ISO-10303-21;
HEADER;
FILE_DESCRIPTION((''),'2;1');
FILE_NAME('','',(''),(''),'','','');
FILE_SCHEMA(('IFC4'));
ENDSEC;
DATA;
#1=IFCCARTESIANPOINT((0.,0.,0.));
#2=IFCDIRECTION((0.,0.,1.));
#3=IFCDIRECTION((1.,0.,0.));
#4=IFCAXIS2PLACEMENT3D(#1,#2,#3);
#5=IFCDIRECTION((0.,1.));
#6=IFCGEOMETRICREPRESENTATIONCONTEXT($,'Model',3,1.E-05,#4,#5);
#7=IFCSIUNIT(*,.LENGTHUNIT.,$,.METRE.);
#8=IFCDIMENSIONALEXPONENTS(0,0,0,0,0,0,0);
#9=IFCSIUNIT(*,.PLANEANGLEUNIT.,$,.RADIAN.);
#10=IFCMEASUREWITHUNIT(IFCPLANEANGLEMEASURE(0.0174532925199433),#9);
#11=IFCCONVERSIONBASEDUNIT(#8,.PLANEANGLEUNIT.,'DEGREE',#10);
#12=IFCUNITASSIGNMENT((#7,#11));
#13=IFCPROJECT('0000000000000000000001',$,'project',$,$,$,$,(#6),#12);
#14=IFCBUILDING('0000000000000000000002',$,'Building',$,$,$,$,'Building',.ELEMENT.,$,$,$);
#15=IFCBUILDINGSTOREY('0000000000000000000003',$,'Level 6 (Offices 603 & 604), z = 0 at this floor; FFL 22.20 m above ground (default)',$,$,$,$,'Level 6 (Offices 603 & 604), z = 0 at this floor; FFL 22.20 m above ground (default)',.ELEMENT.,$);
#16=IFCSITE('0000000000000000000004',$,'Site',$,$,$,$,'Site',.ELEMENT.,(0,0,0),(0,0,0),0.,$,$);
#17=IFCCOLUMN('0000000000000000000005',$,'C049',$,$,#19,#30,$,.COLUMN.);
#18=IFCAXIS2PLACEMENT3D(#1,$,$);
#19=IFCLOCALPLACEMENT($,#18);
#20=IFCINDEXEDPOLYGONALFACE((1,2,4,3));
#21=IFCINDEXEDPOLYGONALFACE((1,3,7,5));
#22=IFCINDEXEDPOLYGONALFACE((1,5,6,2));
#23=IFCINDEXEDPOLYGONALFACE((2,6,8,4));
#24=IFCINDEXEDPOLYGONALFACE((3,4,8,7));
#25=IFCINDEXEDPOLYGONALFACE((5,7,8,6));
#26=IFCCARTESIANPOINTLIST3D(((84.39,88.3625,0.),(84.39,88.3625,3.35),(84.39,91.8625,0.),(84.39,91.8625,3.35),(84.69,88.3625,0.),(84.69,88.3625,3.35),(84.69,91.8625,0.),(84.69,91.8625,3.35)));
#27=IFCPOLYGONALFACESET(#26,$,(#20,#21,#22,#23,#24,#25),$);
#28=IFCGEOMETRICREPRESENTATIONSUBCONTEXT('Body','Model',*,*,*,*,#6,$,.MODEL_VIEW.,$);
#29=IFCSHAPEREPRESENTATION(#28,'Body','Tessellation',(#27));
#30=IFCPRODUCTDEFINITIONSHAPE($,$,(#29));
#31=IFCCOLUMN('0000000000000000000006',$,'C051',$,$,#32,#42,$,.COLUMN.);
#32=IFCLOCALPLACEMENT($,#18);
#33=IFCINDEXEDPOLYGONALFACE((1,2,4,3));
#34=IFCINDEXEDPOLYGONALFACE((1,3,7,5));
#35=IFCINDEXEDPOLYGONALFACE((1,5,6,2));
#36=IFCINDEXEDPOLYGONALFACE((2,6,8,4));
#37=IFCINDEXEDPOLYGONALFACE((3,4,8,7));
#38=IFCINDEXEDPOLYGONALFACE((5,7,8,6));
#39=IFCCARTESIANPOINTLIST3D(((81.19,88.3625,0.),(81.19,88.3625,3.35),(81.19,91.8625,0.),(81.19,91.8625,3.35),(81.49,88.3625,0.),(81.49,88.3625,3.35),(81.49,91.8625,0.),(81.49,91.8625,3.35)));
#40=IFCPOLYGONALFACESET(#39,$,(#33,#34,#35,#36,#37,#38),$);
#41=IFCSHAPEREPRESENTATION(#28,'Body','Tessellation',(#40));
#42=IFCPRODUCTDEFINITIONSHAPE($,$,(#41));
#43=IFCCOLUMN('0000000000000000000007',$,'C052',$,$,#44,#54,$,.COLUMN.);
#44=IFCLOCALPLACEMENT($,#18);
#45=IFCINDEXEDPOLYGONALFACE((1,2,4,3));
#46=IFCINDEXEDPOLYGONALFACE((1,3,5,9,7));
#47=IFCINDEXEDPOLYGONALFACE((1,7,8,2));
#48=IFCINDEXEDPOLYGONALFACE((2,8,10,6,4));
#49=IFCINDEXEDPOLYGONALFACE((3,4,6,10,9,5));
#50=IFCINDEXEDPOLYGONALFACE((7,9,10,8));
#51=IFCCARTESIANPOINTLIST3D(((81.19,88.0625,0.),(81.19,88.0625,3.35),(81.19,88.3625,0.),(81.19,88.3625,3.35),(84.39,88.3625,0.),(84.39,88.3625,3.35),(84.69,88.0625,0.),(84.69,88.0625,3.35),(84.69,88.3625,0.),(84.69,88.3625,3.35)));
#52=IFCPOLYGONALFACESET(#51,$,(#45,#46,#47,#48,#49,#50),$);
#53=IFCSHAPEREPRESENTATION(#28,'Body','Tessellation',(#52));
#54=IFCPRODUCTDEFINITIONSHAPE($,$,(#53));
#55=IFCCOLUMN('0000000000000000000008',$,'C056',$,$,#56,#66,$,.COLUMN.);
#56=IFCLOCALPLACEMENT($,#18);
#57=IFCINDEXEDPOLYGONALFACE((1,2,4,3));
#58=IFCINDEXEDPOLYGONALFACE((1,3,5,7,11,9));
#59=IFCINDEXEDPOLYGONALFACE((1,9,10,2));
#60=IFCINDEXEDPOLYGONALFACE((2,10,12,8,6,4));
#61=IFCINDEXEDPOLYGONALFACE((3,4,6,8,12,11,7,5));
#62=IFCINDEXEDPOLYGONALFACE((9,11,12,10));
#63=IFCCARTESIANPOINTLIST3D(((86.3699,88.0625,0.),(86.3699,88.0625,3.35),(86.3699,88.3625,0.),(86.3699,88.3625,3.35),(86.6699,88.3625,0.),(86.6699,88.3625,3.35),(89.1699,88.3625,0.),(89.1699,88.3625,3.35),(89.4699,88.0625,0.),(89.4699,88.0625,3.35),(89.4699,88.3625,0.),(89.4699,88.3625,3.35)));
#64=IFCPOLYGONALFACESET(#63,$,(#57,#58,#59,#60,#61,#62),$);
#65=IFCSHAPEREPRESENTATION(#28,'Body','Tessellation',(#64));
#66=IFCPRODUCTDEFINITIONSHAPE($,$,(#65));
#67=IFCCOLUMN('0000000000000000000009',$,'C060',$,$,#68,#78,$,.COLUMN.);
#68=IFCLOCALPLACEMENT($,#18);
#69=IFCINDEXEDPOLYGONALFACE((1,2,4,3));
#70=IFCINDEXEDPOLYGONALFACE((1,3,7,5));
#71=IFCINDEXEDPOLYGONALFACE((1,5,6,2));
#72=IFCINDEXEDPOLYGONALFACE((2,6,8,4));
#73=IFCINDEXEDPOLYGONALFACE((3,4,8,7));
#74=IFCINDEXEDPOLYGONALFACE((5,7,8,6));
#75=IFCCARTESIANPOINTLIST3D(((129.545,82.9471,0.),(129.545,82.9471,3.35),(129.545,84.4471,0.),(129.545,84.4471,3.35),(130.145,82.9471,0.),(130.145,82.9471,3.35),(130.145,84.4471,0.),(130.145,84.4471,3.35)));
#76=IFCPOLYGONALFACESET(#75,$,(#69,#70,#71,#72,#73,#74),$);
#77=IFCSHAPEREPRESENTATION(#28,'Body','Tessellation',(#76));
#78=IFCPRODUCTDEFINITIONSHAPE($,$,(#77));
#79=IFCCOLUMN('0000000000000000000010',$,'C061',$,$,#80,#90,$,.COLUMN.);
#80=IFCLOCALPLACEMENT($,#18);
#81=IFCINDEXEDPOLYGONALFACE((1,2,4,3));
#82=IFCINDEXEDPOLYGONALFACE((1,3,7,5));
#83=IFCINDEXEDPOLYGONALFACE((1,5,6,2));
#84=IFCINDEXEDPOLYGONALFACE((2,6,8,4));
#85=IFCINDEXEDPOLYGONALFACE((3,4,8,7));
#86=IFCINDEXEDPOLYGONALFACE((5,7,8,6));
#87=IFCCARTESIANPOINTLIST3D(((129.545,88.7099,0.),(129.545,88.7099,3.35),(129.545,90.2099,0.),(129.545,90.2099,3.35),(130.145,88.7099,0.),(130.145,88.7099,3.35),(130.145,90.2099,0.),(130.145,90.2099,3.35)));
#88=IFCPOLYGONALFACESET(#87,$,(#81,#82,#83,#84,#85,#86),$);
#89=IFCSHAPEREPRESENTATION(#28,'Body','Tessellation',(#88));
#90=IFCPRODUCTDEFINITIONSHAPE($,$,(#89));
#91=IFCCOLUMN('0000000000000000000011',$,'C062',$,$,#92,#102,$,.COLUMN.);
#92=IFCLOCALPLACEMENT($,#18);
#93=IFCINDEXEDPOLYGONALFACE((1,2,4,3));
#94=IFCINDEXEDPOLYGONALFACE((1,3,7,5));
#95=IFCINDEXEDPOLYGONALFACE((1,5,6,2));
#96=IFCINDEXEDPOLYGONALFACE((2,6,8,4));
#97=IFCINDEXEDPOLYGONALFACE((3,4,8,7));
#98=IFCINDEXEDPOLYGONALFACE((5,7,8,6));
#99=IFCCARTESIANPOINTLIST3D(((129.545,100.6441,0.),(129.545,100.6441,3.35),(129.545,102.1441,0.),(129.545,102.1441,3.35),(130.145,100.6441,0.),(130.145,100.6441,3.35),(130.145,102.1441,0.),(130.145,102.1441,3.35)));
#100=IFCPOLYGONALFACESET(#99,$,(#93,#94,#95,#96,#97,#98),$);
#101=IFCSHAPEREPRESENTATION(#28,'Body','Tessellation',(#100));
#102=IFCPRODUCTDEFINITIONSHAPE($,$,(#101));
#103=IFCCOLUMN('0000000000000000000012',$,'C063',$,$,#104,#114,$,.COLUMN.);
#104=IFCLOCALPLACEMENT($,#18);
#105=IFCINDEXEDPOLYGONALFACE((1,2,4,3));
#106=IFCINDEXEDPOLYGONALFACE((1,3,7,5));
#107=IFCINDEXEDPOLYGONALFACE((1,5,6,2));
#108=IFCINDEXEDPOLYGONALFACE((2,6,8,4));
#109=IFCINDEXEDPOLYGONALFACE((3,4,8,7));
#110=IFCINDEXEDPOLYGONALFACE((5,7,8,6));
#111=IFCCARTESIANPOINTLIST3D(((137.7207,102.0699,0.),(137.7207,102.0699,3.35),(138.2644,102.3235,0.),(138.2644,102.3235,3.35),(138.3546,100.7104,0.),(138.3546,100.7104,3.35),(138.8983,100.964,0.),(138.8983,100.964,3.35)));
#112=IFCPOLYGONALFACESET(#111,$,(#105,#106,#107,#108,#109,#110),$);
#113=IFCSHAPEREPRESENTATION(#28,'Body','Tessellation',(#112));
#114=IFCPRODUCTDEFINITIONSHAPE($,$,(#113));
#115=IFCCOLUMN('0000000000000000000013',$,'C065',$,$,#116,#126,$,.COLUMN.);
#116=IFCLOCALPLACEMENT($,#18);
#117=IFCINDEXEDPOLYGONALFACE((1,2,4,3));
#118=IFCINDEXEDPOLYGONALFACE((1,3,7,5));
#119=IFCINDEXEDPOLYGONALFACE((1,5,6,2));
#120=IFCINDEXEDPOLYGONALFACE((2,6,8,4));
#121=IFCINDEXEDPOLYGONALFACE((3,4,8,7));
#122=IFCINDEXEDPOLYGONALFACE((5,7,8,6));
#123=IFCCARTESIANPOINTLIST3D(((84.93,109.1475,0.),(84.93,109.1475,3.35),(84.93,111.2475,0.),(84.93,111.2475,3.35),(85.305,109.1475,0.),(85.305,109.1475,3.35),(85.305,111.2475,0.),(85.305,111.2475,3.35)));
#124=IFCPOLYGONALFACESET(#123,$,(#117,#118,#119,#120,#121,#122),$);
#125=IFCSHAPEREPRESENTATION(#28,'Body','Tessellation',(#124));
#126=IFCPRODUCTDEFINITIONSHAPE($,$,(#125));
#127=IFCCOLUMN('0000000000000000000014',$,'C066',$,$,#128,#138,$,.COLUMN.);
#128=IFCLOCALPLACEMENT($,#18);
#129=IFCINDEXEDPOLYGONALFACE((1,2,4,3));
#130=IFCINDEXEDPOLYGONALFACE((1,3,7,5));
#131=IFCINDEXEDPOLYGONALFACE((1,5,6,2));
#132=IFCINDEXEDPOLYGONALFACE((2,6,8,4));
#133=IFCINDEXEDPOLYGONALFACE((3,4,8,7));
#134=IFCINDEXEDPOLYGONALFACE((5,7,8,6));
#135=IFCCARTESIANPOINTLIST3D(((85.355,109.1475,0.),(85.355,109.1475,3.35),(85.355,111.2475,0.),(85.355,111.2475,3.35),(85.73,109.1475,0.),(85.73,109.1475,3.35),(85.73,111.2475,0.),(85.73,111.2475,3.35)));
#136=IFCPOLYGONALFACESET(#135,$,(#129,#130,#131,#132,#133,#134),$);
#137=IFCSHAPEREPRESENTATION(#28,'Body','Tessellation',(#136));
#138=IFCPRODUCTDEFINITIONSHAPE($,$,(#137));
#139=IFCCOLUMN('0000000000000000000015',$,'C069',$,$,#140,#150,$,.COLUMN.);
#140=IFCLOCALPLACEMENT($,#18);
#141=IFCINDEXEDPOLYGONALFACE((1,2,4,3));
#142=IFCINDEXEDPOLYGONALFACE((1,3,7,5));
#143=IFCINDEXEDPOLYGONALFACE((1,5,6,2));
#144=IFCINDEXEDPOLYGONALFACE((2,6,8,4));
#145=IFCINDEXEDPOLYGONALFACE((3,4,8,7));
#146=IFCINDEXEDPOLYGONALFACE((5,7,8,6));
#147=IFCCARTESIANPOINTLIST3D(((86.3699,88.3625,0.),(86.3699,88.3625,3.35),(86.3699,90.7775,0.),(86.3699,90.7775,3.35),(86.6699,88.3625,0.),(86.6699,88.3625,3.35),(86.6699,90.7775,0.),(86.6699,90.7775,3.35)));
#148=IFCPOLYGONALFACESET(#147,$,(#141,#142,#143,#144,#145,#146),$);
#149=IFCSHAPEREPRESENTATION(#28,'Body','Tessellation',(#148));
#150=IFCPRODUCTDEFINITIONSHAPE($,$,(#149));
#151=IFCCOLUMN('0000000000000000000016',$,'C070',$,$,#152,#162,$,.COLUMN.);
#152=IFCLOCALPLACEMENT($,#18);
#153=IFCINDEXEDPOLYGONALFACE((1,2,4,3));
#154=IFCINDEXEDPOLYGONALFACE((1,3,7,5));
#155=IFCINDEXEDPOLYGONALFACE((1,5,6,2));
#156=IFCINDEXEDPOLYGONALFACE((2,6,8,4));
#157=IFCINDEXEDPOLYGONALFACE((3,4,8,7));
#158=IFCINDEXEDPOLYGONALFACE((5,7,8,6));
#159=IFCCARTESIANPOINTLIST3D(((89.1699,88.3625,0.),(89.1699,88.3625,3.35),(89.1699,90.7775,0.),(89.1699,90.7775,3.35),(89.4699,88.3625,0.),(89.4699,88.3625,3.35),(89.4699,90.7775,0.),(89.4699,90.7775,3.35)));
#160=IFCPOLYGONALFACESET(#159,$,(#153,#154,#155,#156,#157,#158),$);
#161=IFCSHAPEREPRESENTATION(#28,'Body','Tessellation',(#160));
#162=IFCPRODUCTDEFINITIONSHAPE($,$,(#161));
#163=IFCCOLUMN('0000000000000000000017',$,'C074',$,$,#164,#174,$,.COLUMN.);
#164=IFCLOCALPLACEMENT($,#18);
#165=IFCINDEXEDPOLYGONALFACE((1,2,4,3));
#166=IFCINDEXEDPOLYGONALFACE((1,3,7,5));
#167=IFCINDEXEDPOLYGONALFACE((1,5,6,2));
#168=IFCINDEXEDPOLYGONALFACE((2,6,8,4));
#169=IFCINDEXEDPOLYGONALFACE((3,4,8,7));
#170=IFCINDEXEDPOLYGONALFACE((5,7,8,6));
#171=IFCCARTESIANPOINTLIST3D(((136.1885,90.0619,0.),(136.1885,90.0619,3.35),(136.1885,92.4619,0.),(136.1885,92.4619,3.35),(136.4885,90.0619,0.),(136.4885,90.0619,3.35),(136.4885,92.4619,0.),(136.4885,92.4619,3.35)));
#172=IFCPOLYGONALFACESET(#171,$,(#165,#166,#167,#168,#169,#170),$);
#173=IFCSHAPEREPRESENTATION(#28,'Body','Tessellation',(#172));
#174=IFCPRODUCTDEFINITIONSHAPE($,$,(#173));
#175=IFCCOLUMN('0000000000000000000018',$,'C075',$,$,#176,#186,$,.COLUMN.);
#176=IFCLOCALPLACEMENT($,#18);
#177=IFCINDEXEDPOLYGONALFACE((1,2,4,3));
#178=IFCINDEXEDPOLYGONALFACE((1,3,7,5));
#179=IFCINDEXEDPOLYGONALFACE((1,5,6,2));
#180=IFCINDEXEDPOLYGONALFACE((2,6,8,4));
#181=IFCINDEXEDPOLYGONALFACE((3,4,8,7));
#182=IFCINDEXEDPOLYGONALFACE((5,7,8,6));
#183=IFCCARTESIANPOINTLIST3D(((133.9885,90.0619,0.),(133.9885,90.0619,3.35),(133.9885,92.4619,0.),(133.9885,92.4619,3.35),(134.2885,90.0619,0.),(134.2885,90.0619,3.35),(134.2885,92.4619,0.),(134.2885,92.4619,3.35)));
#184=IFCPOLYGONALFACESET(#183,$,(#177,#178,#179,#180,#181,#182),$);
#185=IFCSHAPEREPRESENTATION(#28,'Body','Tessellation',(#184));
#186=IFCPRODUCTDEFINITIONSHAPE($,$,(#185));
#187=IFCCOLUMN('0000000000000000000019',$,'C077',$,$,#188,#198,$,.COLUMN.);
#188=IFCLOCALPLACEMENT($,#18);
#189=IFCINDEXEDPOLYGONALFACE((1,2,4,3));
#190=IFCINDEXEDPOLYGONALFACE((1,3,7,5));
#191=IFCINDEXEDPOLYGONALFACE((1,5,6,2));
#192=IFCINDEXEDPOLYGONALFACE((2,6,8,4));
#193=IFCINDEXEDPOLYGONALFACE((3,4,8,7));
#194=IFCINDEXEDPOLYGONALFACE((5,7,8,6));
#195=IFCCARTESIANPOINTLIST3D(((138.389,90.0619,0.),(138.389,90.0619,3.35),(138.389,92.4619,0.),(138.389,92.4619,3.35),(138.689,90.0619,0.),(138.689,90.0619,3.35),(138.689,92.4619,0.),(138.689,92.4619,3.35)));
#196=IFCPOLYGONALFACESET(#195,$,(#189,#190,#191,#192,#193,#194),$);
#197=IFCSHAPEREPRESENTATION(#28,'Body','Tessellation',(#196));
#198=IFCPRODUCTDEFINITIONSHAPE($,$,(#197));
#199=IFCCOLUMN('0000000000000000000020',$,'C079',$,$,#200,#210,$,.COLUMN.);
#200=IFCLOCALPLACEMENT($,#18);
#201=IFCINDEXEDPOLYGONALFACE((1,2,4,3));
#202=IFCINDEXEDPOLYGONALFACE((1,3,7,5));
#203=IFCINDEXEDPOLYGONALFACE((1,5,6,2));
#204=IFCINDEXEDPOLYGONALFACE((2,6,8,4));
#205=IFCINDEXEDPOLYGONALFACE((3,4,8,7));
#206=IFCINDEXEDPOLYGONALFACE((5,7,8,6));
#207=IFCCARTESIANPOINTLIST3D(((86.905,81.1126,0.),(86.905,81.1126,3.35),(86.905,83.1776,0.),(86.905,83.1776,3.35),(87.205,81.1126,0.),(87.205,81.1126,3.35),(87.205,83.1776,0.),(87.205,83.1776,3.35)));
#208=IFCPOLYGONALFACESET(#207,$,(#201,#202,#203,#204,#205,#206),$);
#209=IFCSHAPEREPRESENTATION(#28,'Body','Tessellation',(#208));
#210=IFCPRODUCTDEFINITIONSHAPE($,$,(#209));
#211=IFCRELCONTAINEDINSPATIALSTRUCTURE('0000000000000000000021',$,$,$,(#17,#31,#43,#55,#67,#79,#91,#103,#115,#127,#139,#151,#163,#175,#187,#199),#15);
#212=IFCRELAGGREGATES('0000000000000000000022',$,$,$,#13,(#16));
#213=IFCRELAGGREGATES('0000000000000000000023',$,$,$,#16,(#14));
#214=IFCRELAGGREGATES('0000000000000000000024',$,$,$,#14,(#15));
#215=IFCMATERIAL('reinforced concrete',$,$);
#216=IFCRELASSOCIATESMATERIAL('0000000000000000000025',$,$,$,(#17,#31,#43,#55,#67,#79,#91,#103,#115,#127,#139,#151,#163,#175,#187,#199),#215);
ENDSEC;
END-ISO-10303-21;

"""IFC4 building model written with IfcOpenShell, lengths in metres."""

from ifc_helpers import new_model, entity, si_unit, converted_unit, direction, frame, frame_2d, origin_with_axes, origin_2d_with_axis, place, context, subcontext, project, spatial, polyline, rectangle, outline, extrude, material, element, save


model = new_model("IFC4")

# Units and contexts
model_context = context("Model", 3, precision=1e-05, world=origin_with_axes(), true_north=direction((0.0, 1.0)))
body_context = subcontext(model_context, "Body", "Model", "MODEL_VIEW")
ifc_project = project(units=[si_unit("LENGTHUNIT", "METRE"), converted_unit("PLANEANGLEUNIT", "DEGREE", entity("IfcPlaneAngleMeasure", 0.0174532925199433), si_unit("PLANEANGLEUNIT", "RADIAN"), dimensions=[0, 0, 0, 0, 0, 0, 0])], contexts=[model_context])

# Site, building, storey
site = spatial("IfcSite", under=ifc_project, Name="Site", LongName="Site", CompositionType="ELEMENT", RefLatitude=(0, 0, 0), RefLongitude=(0, 0, 0), RefElevation=0.0)
building = spatial("IfcBuilding", under=site, Name="Building", LongName="Building", CompositionType="ELEMENT")
storey = spatial("IfcBuildingStorey", under=building, Name="Level 6 (Offices 603 & 604), z = 0 at this floor; FFL 22.20 m above ground (default)", LongName="Level 6 (Offices 603 & 604), z = 0 at this floor; FFL 22.20 m above ground (default)", CompositionType="ELEMENT")

# Columns
ifc_material = material(Name="reinforced concrete")
placement = place(None, origin_with_axes())
element("IfcColumn", 1, at=placement, inside=storey, material=ifc_material, Name="C049", PredefinedType="COLUMN", context=body_context, shape_type="SweptSolid", body=[
    extrude(rectangle(XDim=3.5, YDim=0.3, at=frame_2d((0.0, 0.0), x_axis=(0.0, -1.0))), frame((84.54, 90.1125, 0.0), z_axis=(0.0, 0.0, 1.0), x_axis=(1.0, 0.0, 0.0)), (0.0, 0.0, 1.0), 3.35),
])
element("IfcColumn", 2, at=placement, inside=storey, material=ifc_material, Name="C051", PredefinedType="COLUMN", context=body_context, shape_type="SweptSolid", body=[
    extrude(rectangle(XDim=3.5, YDim=0.3, at=frame_2d((0.0, 0.0), x_axis=(0.0, -1.0))), frame((81.34, 90.1125, 0.0), z_axis=(0.0, 0.0, 1.0), x_axis=(1.0, 0.0, 0.0)), (0.0, 0.0, 1.0), 3.35),
])
element("IfcColumn", 3, at=placement, inside=storey, material=ifc_material, Name="C052", PredefinedType="COLUMN", context=body_context, shape_type="SweptSolid", body=[
    extrude(outline(polyline([(1.75, 0.15), (1.75, -0.15), (-1.75, -0.15), (-1.75, 0.15), (1.45, 0.15), (1.75, 0.15)])), frame((82.94, 88.2125, 0.0), z_axis=(0.0, 0.0, 1.0), x_axis=(1.0, 0.0, 0.0)), (0.0, 0.0, 1.0), 3.35),
])
element("IfcColumn", 4, at=placement, inside=storey, material=ifc_material, Name="C056", PredefinedType="COLUMN", context=body_context, shape_type="SweptSolid", body=[
    extrude(outline(polyline([(1.55, -0.15), (-1.55, -0.15), (-1.55, 0.15), (-1.25, 0.15), (1.25, 0.15), (1.55, 0.15), (1.55, -0.15)])), frame((87.9199, 88.2125, 0.0), z_axis=(0.0, 0.0, 1.0), x_axis=(1.0, 0.0, 0.0)), (0.0, 0.0, 1.0), 3.35),
])
element("IfcColumn", 5, at=placement, inside=storey, material=ifc_material, Name="C060", PredefinedType="COLUMN", context=body_context, shape_type="SweptSolid", body=[
    extrude(rectangle(XDim=1.5, YDim=0.6, at=frame_2d((0.0, 0.0), x_axis=(0.0, -1.0))), frame((129.845, 83.6971, 0.0), z_axis=(0.0, 0.0, 1.0), x_axis=(1.0, 0.0, 0.0)), (0.0, 0.0, 1.0), 3.35),
])
element("IfcColumn", 6, at=placement, inside=storey, material=ifc_material, Name="C061", PredefinedType="COLUMN", context=body_context, shape_type="SweptSolid", body=[
    extrude(rectangle(XDim=1.5, YDim=0.6, at=frame_2d((0.0, 0.0), x_axis=(0.0, -1.0))), frame((129.845, 89.4599, 0.0), z_axis=(0.0, 0.0, 1.0), x_axis=(1.0, 0.0, 0.0)), (0.0, 0.0, 1.0), 3.35),
])
element("IfcColumn", 7, at=placement, inside=storey, material=ifc_material, Name="C062", PredefinedType="COLUMN", context=body_context, shape_type="SweptSolid", body=[
    extrude(rectangle(XDim=1.5, YDim=0.6, at=frame_2d((0.0, 0.0), x_axis=(0.0, -1.0))), frame((129.845, 101.3941, 0.0), z_axis=(0.0, 0.0, 1.0), x_axis=(1.0, 0.0, 0.0)), (0.0, 0.0, 1.0), 3.35),
])
element("IfcColumn", 8, at=placement, inside=storey, material=ifc_material, Name="C063", PredefinedType="COLUMN", context=body_context, shape_type="SweptSolid", body=[
    extrude(rectangle(XDim=1.5, YDim=0.5999, at=frame_2d((0.0, 0.0), x_axis=(-0.422593, 0.906319))), frame((138.3095, 101.5169, 0.0), z_axis=(0.0, 0.0, 1.0), x_axis=(1.0, 0.0, 0.0)), (0.0, 0.0, 1.0), 3.35),
])
element("IfcColumn", 9, at=placement, inside=storey, material=ifc_material, Name="C065", PredefinedType="COLUMN", context=body_context, shape_type="SweptSolid", body=[
    extrude(rectangle(XDim=0.375, YDim=2.1, at=frame_2d((0.0, 0.0), x_axis=(1.0, 0.0))), frame((85.1175, 110.1975, 0.0), z_axis=(0.0, 0.0, 1.0), x_axis=(1.0, 0.0, 0.0)), (0.0, 0.0, 1.0), 3.35),
])
element("IfcColumn", 10, at=placement, inside=storey, material=ifc_material, Name="C066", PredefinedType="COLUMN", context=body_context, shape_type="SweptSolid", body=[
    extrude(rectangle(XDim=0.375, YDim=2.1, at=frame_2d((0.0, 0.0), x_axis=(1.0, 0.0))), frame((85.5425, 110.1975, 0.0), z_axis=(0.0, 0.0, 1.0), x_axis=(1.0, 0.0, 0.0)), (0.0, 0.0, 1.0), 3.35),
])
element("IfcColumn", 11, at=placement, inside=storey, material=ifc_material, Name="C069", PredefinedType="COLUMN", context=body_context, shape_type="SweptSolid", body=[
    extrude(rectangle(XDim=0.3, YDim=2.415, at=origin_2d_with_axis()), frame((86.5199, 89.57, 0.0), z_axis=(0.0, 0.0, 1.0), x_axis=(1.0, 0.0, 0.0)), (0.0, 0.0, 1.0), 3.35),
])
element("IfcColumn", 12, at=placement, inside=storey, material=ifc_material, Name="C070", PredefinedType="COLUMN", context=body_context, shape_type="SweptSolid", body=[
    extrude(rectangle(XDim=2.415, YDim=0.3, at=frame_2d((0.0, 0.0), x_axis=(0.0, -1.0))), frame((89.3199, 89.57, 0.0), z_axis=(0.0, 0.0, 1.0), x_axis=(1.0, 0.0, 0.0)), (0.0, 0.0, 1.0), 3.35),
])
element("IfcColumn", 13, at=placement, inside=storey, material=ifc_material, Name="C074", PredefinedType="COLUMN", context=body_context, shape_type="SweptSolid", body=[
    extrude(rectangle(XDim=2.4, YDim=0.3, at=frame_2d((0.0, 0.0), x_axis=(0.0, -1.0))), frame((136.3385, 91.2619, 0.0), z_axis=(0.0, 0.0, 1.0), x_axis=(1.0, 0.0, 0.0)), (0.0, 0.0, 1.0), 3.35),
])
element("IfcColumn", 14, at=placement, inside=storey, material=ifc_material, Name="C075", PredefinedType="COLUMN", context=body_context, shape_type="SweptSolid", body=[
    extrude(rectangle(XDim=2.4, YDim=0.3, at=frame_2d((0.0, 0.0), x_axis=(0.0, -1.0))), frame((134.1385, 91.2619, 0.0), z_axis=(0.0, 0.0, 1.0), x_axis=(1.0, 0.0, 0.0)), (0.0, 0.0, 1.0), 3.35),
])
element("IfcColumn", 15, at=placement, inside=storey, material=ifc_material, Name="C077", PredefinedType="COLUMN", context=body_context, shape_type="SweptSolid", body=[
    extrude(rectangle(XDim=2.4, YDim=0.3, at=frame_2d((0.0, 0.0), x_axis=(0.0, -1.0))), frame((138.539, 91.2619, 0.0), z_axis=(0.0, 0.0, 1.0), x_axis=(1.0, 0.0, 0.0)), (0.0, 0.0, 1.0), 3.35),
])
element("IfcColumn", 16, at=placement, inside=storey, material=ifc_material, Name="C079", PredefinedType="COLUMN", context=body_context, shape_type="SweptSolid", body=[
    extrude(rectangle(XDim=2.065, YDim=0.3, at=frame_2d((0.0, 0.0), x_axis=(0.0, -1.0))), frame((87.055, 82.1451, 0.0), z_axis=(0.0, 0.0, 1.0), x_axis=(1.0, 0.0, 0.0)), (0.0, 0.0, 1.0), 3.35),
])

save(model, "model.ifc")
